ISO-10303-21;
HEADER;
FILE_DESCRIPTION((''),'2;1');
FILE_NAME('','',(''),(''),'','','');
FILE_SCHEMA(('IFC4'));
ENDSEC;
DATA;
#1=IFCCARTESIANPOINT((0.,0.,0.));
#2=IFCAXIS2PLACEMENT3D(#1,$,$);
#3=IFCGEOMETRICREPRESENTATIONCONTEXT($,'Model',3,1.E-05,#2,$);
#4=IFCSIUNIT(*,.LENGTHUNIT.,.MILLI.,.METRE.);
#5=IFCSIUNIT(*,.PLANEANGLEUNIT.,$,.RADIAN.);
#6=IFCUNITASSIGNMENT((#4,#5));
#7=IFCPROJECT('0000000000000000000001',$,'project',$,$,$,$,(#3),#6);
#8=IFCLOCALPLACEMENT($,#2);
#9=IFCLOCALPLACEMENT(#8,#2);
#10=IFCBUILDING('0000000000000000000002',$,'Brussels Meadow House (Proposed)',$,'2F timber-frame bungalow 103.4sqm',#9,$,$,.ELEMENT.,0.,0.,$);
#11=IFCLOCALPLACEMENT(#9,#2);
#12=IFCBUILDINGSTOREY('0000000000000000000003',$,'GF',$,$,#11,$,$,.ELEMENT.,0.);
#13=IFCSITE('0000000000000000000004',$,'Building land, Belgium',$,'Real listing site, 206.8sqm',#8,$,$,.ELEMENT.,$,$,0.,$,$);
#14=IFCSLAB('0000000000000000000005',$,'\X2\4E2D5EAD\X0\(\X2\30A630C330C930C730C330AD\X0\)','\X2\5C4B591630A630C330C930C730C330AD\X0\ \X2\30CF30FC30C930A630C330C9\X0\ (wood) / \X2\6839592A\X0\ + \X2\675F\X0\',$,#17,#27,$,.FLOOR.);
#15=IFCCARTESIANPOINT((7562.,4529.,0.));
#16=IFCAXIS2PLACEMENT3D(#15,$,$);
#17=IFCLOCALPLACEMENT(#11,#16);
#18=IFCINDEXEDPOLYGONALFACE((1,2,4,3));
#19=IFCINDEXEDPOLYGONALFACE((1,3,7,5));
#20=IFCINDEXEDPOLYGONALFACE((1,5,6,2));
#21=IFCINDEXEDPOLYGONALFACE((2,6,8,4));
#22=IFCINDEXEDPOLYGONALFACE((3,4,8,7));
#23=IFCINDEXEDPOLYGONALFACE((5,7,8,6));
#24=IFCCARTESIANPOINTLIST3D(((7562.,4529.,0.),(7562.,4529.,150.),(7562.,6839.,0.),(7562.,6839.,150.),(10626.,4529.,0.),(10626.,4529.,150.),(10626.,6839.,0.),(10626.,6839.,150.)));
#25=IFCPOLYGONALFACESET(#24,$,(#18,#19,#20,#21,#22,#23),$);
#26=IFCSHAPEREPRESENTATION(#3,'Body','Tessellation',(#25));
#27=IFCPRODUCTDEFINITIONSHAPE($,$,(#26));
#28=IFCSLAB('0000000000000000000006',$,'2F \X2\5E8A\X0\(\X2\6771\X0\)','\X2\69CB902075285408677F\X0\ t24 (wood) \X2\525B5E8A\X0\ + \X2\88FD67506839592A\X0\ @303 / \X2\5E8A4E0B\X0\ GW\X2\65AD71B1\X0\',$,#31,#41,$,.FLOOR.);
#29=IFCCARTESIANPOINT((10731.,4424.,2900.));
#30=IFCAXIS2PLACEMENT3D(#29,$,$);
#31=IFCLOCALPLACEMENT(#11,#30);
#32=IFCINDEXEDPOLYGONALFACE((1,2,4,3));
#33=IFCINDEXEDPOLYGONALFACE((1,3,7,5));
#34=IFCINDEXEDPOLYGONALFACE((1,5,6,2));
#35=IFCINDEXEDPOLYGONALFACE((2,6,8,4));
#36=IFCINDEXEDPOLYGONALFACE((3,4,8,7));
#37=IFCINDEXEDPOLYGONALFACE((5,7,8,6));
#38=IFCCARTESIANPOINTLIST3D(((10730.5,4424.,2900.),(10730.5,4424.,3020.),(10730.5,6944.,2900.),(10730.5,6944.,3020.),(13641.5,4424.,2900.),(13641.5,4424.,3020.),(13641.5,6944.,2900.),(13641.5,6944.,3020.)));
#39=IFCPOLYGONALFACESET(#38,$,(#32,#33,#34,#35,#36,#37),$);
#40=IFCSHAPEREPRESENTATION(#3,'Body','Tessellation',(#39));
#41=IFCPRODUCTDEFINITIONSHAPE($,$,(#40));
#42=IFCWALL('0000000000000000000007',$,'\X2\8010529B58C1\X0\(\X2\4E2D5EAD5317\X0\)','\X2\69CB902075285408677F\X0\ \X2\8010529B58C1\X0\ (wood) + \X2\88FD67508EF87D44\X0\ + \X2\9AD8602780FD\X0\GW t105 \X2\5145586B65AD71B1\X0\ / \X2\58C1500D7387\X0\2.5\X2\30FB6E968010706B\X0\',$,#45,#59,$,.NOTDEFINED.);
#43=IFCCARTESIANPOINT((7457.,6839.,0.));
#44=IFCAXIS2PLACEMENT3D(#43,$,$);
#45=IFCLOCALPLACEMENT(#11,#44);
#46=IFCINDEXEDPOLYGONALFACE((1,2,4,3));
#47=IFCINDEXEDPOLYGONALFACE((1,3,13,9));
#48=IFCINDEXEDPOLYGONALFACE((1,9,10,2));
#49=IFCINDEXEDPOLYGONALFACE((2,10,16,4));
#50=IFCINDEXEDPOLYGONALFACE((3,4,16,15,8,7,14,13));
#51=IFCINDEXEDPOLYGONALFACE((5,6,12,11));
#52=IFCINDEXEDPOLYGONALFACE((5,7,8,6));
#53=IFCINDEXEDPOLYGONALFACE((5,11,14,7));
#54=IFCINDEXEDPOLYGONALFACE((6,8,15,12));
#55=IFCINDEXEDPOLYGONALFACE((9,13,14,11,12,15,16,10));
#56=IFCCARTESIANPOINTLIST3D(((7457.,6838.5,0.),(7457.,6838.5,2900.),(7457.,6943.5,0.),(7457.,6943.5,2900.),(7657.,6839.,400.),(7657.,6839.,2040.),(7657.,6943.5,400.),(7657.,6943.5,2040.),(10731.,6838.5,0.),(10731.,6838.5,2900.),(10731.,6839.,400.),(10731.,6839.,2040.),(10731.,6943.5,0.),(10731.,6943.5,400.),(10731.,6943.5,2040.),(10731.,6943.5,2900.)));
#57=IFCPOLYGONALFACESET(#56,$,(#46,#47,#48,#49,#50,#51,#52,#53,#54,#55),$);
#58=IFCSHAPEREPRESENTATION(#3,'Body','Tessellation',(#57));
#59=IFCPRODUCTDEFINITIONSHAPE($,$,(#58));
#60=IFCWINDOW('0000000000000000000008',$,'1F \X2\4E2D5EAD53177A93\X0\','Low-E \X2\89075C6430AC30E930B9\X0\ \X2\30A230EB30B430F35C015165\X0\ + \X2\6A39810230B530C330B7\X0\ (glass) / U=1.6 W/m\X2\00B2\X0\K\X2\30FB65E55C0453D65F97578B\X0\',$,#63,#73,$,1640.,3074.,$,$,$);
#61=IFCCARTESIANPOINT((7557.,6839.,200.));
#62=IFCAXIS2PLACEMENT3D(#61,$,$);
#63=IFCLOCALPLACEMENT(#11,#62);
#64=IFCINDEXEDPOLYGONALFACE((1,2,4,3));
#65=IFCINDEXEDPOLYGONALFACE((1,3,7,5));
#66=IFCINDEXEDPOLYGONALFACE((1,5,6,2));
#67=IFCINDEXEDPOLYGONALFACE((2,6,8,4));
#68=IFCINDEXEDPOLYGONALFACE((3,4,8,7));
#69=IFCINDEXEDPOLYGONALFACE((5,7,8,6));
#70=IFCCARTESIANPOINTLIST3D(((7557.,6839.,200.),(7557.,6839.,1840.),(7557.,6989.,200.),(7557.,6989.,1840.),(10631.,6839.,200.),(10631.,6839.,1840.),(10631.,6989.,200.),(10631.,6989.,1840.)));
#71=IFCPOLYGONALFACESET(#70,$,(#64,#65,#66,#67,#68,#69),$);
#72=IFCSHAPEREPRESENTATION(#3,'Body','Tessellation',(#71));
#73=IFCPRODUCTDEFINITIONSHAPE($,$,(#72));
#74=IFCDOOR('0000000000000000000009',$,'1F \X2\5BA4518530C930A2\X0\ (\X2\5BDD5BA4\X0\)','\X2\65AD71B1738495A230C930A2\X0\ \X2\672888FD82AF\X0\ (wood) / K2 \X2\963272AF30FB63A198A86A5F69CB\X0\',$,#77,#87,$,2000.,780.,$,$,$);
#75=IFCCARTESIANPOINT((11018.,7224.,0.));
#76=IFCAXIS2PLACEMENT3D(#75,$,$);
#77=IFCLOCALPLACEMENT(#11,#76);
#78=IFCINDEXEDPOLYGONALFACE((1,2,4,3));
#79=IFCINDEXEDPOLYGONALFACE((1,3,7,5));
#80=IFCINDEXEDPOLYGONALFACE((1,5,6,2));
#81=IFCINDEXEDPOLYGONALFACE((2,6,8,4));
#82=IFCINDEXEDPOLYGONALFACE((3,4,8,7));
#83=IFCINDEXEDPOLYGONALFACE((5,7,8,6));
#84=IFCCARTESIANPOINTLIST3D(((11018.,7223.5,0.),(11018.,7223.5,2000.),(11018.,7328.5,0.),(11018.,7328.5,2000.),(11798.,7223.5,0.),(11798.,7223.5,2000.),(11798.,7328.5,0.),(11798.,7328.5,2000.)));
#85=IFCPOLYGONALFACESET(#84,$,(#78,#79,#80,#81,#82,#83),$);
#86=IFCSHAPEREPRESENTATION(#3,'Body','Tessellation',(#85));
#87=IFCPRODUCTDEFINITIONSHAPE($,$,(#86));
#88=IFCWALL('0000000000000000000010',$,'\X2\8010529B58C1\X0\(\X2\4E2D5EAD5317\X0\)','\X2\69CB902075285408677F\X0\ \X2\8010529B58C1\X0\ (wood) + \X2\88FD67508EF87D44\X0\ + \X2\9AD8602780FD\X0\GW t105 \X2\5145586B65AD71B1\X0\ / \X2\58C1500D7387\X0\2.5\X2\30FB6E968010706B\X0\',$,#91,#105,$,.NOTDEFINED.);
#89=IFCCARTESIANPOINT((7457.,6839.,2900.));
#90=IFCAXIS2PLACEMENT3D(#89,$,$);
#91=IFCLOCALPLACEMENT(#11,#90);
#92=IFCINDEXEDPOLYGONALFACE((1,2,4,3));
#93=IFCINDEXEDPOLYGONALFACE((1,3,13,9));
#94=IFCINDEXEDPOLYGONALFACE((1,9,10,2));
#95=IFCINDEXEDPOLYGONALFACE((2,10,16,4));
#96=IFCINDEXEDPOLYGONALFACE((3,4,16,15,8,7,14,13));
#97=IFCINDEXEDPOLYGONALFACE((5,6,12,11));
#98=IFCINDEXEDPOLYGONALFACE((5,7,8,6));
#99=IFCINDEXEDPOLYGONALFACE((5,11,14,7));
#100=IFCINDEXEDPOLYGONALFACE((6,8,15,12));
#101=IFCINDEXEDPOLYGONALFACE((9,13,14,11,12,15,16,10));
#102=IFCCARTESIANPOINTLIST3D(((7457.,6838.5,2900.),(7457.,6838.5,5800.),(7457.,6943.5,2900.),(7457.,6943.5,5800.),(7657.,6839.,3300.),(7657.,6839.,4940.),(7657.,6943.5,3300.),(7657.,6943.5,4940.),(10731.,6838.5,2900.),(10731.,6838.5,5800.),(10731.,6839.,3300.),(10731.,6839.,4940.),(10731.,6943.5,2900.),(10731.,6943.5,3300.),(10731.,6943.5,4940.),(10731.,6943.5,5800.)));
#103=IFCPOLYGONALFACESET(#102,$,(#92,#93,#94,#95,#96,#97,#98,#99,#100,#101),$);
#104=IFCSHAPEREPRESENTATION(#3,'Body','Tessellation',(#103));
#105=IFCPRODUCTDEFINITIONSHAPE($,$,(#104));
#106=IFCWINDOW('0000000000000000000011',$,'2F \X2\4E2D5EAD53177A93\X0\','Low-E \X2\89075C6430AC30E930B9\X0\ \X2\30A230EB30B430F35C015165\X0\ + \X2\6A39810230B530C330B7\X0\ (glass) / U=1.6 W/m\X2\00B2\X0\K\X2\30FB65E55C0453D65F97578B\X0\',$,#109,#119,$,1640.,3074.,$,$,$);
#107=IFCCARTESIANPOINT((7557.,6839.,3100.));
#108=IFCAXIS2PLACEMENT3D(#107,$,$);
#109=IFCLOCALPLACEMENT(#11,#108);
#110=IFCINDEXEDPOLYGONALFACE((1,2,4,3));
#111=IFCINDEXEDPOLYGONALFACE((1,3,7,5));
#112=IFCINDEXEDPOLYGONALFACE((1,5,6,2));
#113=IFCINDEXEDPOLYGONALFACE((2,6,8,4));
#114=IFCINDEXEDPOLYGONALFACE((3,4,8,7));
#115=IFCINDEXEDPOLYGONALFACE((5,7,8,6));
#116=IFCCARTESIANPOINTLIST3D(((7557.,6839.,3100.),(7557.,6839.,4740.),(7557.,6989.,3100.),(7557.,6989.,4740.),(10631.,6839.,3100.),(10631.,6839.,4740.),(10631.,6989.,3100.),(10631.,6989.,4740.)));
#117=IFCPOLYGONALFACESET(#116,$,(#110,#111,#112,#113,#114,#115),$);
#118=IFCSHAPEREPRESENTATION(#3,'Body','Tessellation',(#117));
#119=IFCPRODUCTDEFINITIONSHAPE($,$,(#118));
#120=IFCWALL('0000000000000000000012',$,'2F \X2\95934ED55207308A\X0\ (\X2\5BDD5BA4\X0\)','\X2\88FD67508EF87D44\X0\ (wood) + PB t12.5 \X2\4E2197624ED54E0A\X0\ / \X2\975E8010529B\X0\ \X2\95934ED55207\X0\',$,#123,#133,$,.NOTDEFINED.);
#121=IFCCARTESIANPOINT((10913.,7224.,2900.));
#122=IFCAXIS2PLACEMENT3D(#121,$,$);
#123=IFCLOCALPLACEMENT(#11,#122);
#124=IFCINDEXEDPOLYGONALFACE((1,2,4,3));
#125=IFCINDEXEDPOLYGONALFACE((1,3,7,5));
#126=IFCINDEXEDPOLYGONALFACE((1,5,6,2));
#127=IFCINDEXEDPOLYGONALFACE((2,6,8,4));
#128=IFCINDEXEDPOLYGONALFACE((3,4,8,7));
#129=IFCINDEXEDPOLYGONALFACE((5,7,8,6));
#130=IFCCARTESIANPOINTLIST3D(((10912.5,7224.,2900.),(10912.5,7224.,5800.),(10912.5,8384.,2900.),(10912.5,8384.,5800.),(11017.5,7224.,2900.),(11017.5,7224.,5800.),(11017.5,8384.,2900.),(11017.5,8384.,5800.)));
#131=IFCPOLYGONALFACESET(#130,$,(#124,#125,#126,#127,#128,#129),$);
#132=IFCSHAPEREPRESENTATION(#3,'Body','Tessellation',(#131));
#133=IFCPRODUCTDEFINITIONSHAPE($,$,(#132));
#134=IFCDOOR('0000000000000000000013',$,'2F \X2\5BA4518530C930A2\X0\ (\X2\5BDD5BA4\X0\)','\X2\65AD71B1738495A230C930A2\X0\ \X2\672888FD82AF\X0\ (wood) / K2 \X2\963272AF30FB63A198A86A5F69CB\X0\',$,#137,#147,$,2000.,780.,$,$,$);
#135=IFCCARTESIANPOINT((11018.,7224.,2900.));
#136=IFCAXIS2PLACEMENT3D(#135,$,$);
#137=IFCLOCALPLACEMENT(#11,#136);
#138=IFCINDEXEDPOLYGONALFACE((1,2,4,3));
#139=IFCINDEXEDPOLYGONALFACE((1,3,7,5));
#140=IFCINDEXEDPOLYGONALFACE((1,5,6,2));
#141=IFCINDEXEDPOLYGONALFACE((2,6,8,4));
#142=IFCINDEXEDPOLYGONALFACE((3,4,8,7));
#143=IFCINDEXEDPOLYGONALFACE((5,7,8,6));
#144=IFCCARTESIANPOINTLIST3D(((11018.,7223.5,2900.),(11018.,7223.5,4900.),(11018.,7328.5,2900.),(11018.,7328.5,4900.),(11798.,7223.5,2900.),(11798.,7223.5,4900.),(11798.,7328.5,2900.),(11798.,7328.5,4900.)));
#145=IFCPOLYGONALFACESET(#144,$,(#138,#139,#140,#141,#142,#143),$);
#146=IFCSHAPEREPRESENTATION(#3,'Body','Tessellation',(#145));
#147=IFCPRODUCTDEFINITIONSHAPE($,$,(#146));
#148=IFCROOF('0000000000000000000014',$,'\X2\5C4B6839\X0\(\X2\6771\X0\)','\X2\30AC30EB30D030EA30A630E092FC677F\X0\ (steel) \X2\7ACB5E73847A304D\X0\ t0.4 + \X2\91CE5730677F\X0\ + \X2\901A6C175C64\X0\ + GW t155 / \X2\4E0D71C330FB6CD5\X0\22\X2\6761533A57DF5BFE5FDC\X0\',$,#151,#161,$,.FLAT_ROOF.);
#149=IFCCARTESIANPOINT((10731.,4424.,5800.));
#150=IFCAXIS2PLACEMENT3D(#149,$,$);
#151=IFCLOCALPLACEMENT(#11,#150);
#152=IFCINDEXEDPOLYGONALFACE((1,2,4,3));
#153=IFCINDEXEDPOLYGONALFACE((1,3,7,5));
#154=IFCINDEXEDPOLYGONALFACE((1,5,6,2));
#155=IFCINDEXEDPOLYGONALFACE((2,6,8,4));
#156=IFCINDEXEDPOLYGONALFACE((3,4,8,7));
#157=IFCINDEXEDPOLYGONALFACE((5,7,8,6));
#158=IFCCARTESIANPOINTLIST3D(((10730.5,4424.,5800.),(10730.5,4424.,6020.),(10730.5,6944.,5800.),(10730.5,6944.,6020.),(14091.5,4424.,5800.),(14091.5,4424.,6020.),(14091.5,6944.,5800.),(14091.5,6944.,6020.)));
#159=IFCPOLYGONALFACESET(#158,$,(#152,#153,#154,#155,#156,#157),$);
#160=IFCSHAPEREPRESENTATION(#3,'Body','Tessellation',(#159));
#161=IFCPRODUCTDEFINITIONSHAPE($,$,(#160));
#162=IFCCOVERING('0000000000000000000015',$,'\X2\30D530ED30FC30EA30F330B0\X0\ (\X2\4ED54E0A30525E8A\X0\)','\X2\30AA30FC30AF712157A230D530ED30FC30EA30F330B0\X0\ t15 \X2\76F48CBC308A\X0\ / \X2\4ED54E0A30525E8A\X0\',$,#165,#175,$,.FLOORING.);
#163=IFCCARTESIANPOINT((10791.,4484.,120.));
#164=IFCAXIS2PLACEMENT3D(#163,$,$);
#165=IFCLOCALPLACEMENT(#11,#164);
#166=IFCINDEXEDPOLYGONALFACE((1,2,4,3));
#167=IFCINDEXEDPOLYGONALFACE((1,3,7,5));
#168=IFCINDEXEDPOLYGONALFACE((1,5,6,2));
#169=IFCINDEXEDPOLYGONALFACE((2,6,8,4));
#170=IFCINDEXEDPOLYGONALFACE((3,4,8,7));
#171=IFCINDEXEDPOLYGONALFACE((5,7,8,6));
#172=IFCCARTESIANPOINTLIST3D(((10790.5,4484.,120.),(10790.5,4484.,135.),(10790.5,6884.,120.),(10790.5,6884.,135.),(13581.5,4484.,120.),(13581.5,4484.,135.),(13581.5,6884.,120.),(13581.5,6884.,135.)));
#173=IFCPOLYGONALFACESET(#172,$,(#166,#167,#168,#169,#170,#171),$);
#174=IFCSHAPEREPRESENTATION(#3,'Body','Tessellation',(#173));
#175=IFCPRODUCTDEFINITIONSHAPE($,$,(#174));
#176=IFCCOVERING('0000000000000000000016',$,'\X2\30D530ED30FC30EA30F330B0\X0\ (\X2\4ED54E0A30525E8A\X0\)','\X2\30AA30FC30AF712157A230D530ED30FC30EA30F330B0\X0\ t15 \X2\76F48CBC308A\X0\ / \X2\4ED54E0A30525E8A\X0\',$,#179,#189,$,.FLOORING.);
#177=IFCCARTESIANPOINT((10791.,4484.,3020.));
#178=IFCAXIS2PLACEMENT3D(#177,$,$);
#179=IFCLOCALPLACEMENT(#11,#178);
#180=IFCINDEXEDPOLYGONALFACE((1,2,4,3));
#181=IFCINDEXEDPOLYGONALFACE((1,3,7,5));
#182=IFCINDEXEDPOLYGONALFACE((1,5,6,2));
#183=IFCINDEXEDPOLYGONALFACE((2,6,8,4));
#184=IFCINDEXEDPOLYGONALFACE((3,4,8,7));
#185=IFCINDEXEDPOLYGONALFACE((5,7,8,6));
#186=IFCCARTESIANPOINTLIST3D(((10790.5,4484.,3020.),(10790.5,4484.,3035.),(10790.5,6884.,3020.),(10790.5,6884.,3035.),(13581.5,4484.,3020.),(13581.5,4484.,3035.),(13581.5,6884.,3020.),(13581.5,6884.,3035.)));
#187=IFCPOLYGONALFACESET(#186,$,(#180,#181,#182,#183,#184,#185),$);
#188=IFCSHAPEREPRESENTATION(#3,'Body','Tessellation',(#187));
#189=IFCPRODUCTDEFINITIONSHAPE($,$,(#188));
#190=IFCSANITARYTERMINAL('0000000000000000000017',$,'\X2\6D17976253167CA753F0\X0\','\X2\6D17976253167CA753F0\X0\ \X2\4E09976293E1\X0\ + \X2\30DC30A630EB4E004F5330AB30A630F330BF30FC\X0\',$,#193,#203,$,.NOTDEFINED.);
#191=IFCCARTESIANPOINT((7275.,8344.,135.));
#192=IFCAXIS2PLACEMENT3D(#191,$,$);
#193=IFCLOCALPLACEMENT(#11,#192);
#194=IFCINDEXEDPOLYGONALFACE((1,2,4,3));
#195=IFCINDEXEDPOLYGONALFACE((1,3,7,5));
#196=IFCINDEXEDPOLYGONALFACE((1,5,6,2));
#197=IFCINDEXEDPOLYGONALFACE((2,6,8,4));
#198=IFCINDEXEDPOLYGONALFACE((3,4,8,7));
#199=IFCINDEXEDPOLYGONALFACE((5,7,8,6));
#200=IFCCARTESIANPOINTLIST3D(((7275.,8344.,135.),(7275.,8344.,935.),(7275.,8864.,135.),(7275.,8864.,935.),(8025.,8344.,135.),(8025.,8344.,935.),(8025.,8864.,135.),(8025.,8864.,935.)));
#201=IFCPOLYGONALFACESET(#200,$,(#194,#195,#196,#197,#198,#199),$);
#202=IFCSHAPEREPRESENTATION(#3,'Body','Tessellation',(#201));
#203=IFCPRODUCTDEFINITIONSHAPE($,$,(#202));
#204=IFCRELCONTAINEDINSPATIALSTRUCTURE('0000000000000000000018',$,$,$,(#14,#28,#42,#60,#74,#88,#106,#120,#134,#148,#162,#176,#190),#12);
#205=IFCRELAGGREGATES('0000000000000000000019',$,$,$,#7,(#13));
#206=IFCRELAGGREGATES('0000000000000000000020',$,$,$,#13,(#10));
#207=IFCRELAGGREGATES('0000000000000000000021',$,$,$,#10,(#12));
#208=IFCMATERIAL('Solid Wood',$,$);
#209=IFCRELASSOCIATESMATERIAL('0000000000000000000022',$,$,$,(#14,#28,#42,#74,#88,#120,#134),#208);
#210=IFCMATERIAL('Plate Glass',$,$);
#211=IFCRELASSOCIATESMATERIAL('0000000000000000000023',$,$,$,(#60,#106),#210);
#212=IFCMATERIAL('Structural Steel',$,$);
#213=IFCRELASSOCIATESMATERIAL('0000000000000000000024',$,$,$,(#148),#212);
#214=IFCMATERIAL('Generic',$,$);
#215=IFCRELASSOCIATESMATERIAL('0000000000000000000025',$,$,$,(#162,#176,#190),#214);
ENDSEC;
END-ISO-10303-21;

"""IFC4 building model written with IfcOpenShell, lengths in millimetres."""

from ifc_helpers import new_model, si_unit, frame, frame_2d, origin, place, context, project, spatial, rectangle, extrude, material, element, fill, save


model = new_model("IFC4")

# Units and contexts
model_context = context("Model", 3, precision=1e-05, world=origin())
ifc_project = project(units=[si_unit("LENGTHUNIT", "METRE", prefix="MILLI"), si_unit("PLANEANGLEUNIT", "RADIAN")], contexts=[model_context])

# Site, building, storey
site_placement = place(None, origin())
site = spatial("IfcSite", under=ifc_project, at=site_placement, Name="Building land, Belgium", ObjectType="Real listing site, 206.8sqm", CompositionType="ELEMENT", RefElevation=0.0)
building_placement = place(site_placement, origin())
building = spatial("IfcBuilding", under=site, at=building_placement, Name="Brussels Meadow House (Proposed)", ObjectType="2F timber-frame bungalow 103.4sqm", CompositionType="ELEMENT", ElevationOfRefHeight=0.0, ElevationOfTerrain=0.0)
storey_placement = place(building_placement, origin())
storey = spatial("IfcBuildingStorey", under=building, at=storey_placement, Name="GF", CompositionType="ELEMENT", Elevation=0.0)

# Slabs
ifc_material_1 = material(Name="Solid Wood")
slab_1_placement = place(storey_placement, frame((7562.0, 4529.0, 0.0)))
element("IfcSlab", 1, at=slab_1_placement, inside=storey, material=ifc_material_1, Name="中庭(ウッドデッキ)", Description="屋外ウッドデッキ ハードウッド (wood) / 根太 + 束", PredefinedType="FLOOR", context=model_context, shape_type="SweptSolid", body=[
    extrude(rectangle(XDim=3064.0, YDim=2310.0, at=frame_2d((1532.0, 1155.0))), frame((7562.0, 4529.0, 0.0)), (0.0, 0.0, 1.0), 150.0),
])
slab_2_placement = place(storey_placement, frame((10731.0, 4424.0, 2900.0)))
element("IfcSlab", 2, at=slab_2_placement, inside=storey, material=ifc_material_1, Name="2F 床(東)", Description="構造用合板 t24 (wood) 剛床 + 製材根太 @303 / 床下 GW断熱", PredefinedType="FLOOR", context=model_context, shape_type="SweptSolid", body=[
    extrude(rectangle(XDim=2911.0, YDim=2520.0, at=frame_2d((1455.0, 1260.0))), frame((10731.0, 4424.0, 2900.0)), (0.0, 0.0, 1.0), 120.0),
])

# Wall, opening, window
wall_1_placement = place(storey_placement, frame((7457.0, 6839.0, 0.0)))
wall_1 = element("IfcWall", 3, at=wall_1_placement, inside=storey, material=ifc_material_1, Name="耐力壁(中庭北)", Description="構造用合板 耐力壁 (wood) + 製材軸組 + 高性能GW t105 充填断熱 / 壁倍率2.5・準耐火", PredefinedType="NOTDEFINED", context=model_context, shape_type="SweptSolid", body=[
    extrude(rectangle(XDim=3274.0, YDim=105.0, at=frame_2d((1637.0, 52.0))), frame((7457.0, 6839.0, 0.0)), (0.0, 0.0, 1.0), 2900.0),
])
opening_1_placement = place(storey_placement, frame((7557.0, 6839.0, 200.0)))
opening_1 = element("IfcOpeningElement", 4, at=opening_1_placement, cuts=wall_1, PredefinedType="NOTDEFINED", context=model_context, shape_type="SweptSolid", body=[
    extrude(rectangle(XDim=3074.0, YDim=150.0, at=frame_2d((1537.0, 75.0))), frame((7557.0, 6839.0, 200.0)), (0.0, 0.0, 1.0), 1640.0),
])
ifc_material_2 = material(Name="Plate Glass")
window_1_placement = place(storey_placement, frame((7557.0, 6839.0, 200.0)))
window_1 = element("IfcWindow", 5, at=window_1_placement, inside=storey, material=ifc_material_2, Name="1F 中庭北窓", Description="Low-E 複層ガラス アルゴン封入 + 樹脂サッシ (glass) / U=1.6 W/m²K・日射取得型", OverallHeight=1640.0, OverallWidth=3074.0, context=model_context, shape_type="SweptSolid", body=[
    extrude(rectangle(XDim=3074.0, YDim=150.0, at=frame_2d((1537.0, 75.0))), frame((7557.0, 6839.0, 200.0)), (0.0, 0.0, 1.0), 1640.0),
])
fill(opening_1, window_1)

# Door
door_1_placement = place(storey_placement, frame((11018.0, 7224.0, 0.0)))
element("IfcDoor", 6, at=door_1_placement, inside=storey, material=ifc_material_1, Name="1F 室内ドア (寝室)", Description="断熱玄関ドア 木製芯 (wood) / K2 防犯・採風機構", OverallHeight=2000.0, OverallWidth=780.0, context=model_context, shape_type="SweptSolid", body=[
    extrude(rectangle(XDim=780.0, YDim=105.0, at=frame_2d((390.0, 52.0))), frame((11018.0, 7224.0, 0.0)), (0.0, 0.0, 1.0), 2000.0),
])

# Wall, opening, window
wall_2_placement = place(storey_placement, frame((7457.0, 6839.0, 2900.0)))
wall_2 = element("IfcWall", 7, at=wall_2_placement, inside=storey, material=ifc_material_1, Name="耐力壁(中庭北)", Description="構造用合板 耐力壁 (wood) + 製材軸組 + 高性能GW t105 充填断熱 / 壁倍率2.5・準耐火", PredefinedType="NOTDEFINED", context=model_context, shape_type="SweptSolid", body=[
    extrude(rectangle(XDim=3274.0, YDim=105.0, at=frame_2d((1637.0, 52.0))), frame((7457.0, 6839.0, 2900.0)), (0.0, 0.0, 1.0), 2900.0),
])
opening_2_placement = place(storey_placement, frame((7557.0, 6839.0, 3100.0)))
opening_2 = element("IfcOpeningElement", 8, at=opening_2_placement, cuts=wall_2, PredefinedType="NOTDEFINED", context=model_context, shape_type="SweptSolid", body=[
    extrude(rectangle(XDim=3074.0, YDim=150.0, at=frame_2d((1537.0, 75.0))), frame((7557.0, 6839.0, 3100.0)), (0.0, 0.0, 1.0), 1640.0),
])
window_2_placement = place(storey_placement, frame((7557.0, 6839.0, 3100.0)))
window_2 = element("IfcWindow", 9, at=window_2_placement, inside=storey, material=ifc_material_2, Name="2F 中庭北窓", Description="Low-E 複層ガラス アルゴン封入 + 樹脂サッシ (glass) / U=1.6 W/m²K・日射取得型", OverallHeight=1640.0, OverallWidth=3074.0, context=model_context, shape_type="SweptSolid", body=[
    extrude(rectangle(XDim=3074.0, YDim=150.0, at=frame_2d((1537.0, 75.0))), frame((7557.0, 6839.0, 3100.0)), (0.0, 0.0, 1.0), 1640.0),
])
fill(opening_2, window_2)

# Wall
wall_3_placement = place(storey_placement, frame((10913.0, 7224.0, 2900.0)))
element("IfcWall", 10, at=wall_3_placement, inside=storey, material=ifc_material_1, Name="2F 間仕切り (寝室)", Description="製材軸組 (wood) + PB t12.5 両面仕上 / 非耐力 間仕切", PredefinedType="NOTDEFINED", context=model_context, shape_type="SweptSolid", body=[
    extrude(rectangle(XDim=105.0, YDim=1160.0, at=frame_2d((52.0, 580.0))), frame((10913.0, 7224.0, 2900.0)), (0.0, 0.0, 1.0), 2900.0),
])

# Door
door_2_placement = place(storey_placement, frame((11018.0, 7224.0, 2900.0)))
element("IfcDoor", 11, at=door_2_placement, inside=storey, material=ifc_material_1, Name="2F 室内ドア (寝室)", Description="断熱玄関ドア 木製芯 (wood) / K2 防犯・採風機構", OverallHeight=2000.0, OverallWidth=780.0, context=model_context, shape_type="SweptSolid", body=[
    extrude(rectangle(XDim=780.0, YDim=105.0, at=frame_2d((390.0, 52.0))), frame((11018.0, 7224.0, 2900.0)), (0.0, 0.0, 1.0), 2000.0),
])

# Roof
ifc_material_3 = material(Name="Structural Steel")
for number, where, name in (
    (12, (10731.0, 4424.0, 5800.0), "屋根(東)"),
):
    element("IfcRoof", number, at=place(storey_placement, frame(where)), inside=storey, material=ifc_material_3, Name=name, Description="ガルバリウム鋼板 (steel) 立平葺き t0.4 + 野地板 + 通気層 + GW t155 / 不燃・法22条区域対応", PredefinedType="FLAT_ROOF", context=model_context, shape_type="SweptSolid", body=[
        extrude(rectangle(XDim=3361.0, YDim=2520.0, at=frame_2d((1680.0, 1260.0))), frame((10731.0, 4424.0, 5800.0)), (0.0, 0.0, 1.0), 220.0),
    ])

# Coverings
ifc_material_4 = material(Name="Generic")
covering_1_placement = place(storey_placement, frame((10791.0, 4484.0, 120.0)))
element("IfcCovering", 13, at=covering_1_placement, inside=storey, material=ifc_material_4, Name="フローリング (仕上げ床)", Description="オーク無垢フローリング t15 直貼り / 仕上げ床", PredefinedType="FLOORING", context=model_context, shape_type="SweptSolid", body=[
    extrude(rectangle(XDim=2791.0, YDim=2400.0, at=frame_2d((1395.0, 1200.0))), frame((10791.0, 4484.0, 120.0)), (0.0, 0.0, 1.0), 15.0),
])
covering_2_placement = place(storey_placement, frame((10791.0, 4484.0, 3020.0)))
element("IfcCovering", 14, at=covering_2_placement, inside=storey, material=ifc_material_4, Name="フローリング (仕上げ床)", Description="オーク無垢フローリング t15 直貼り / 仕上げ床", PredefinedType="FLOORING", context=model_context, shape_type="SweptSolid", body=[
    extrude(rectangle(XDim=2791.0, YDim=2400.0, at=frame_2d((1395.0, 1200.0))), frame((10791.0, 4484.0, 3020.0)), (0.0, 0.0, 1.0), 15.0),
])

# Sanitary terminal
sanitary_terminal_1_placement = place(storey_placement, frame((7275.0, 8344.0, 135.0)))
element("IfcSanitaryTerminal", 15, at=sanitary_terminal_1_placement, inside=storey, material=ifc_material_4, Name="洗面化粧台", Description="洗面化粧台 三面鏡 + ボウル一体カウンター", PredefinedType="NOTDEFINED", context=model_context, shape_type="SweptSolid", body=[
    extrude(rectangle(XDim=750.0, YDim=520.0, at=frame_2d((375.0, 260.0))), frame((7275.0, 8344.0, 135.0)), (0.0, 0.0, 1.0), 800.0),
])

save(model, "model.ifc")
